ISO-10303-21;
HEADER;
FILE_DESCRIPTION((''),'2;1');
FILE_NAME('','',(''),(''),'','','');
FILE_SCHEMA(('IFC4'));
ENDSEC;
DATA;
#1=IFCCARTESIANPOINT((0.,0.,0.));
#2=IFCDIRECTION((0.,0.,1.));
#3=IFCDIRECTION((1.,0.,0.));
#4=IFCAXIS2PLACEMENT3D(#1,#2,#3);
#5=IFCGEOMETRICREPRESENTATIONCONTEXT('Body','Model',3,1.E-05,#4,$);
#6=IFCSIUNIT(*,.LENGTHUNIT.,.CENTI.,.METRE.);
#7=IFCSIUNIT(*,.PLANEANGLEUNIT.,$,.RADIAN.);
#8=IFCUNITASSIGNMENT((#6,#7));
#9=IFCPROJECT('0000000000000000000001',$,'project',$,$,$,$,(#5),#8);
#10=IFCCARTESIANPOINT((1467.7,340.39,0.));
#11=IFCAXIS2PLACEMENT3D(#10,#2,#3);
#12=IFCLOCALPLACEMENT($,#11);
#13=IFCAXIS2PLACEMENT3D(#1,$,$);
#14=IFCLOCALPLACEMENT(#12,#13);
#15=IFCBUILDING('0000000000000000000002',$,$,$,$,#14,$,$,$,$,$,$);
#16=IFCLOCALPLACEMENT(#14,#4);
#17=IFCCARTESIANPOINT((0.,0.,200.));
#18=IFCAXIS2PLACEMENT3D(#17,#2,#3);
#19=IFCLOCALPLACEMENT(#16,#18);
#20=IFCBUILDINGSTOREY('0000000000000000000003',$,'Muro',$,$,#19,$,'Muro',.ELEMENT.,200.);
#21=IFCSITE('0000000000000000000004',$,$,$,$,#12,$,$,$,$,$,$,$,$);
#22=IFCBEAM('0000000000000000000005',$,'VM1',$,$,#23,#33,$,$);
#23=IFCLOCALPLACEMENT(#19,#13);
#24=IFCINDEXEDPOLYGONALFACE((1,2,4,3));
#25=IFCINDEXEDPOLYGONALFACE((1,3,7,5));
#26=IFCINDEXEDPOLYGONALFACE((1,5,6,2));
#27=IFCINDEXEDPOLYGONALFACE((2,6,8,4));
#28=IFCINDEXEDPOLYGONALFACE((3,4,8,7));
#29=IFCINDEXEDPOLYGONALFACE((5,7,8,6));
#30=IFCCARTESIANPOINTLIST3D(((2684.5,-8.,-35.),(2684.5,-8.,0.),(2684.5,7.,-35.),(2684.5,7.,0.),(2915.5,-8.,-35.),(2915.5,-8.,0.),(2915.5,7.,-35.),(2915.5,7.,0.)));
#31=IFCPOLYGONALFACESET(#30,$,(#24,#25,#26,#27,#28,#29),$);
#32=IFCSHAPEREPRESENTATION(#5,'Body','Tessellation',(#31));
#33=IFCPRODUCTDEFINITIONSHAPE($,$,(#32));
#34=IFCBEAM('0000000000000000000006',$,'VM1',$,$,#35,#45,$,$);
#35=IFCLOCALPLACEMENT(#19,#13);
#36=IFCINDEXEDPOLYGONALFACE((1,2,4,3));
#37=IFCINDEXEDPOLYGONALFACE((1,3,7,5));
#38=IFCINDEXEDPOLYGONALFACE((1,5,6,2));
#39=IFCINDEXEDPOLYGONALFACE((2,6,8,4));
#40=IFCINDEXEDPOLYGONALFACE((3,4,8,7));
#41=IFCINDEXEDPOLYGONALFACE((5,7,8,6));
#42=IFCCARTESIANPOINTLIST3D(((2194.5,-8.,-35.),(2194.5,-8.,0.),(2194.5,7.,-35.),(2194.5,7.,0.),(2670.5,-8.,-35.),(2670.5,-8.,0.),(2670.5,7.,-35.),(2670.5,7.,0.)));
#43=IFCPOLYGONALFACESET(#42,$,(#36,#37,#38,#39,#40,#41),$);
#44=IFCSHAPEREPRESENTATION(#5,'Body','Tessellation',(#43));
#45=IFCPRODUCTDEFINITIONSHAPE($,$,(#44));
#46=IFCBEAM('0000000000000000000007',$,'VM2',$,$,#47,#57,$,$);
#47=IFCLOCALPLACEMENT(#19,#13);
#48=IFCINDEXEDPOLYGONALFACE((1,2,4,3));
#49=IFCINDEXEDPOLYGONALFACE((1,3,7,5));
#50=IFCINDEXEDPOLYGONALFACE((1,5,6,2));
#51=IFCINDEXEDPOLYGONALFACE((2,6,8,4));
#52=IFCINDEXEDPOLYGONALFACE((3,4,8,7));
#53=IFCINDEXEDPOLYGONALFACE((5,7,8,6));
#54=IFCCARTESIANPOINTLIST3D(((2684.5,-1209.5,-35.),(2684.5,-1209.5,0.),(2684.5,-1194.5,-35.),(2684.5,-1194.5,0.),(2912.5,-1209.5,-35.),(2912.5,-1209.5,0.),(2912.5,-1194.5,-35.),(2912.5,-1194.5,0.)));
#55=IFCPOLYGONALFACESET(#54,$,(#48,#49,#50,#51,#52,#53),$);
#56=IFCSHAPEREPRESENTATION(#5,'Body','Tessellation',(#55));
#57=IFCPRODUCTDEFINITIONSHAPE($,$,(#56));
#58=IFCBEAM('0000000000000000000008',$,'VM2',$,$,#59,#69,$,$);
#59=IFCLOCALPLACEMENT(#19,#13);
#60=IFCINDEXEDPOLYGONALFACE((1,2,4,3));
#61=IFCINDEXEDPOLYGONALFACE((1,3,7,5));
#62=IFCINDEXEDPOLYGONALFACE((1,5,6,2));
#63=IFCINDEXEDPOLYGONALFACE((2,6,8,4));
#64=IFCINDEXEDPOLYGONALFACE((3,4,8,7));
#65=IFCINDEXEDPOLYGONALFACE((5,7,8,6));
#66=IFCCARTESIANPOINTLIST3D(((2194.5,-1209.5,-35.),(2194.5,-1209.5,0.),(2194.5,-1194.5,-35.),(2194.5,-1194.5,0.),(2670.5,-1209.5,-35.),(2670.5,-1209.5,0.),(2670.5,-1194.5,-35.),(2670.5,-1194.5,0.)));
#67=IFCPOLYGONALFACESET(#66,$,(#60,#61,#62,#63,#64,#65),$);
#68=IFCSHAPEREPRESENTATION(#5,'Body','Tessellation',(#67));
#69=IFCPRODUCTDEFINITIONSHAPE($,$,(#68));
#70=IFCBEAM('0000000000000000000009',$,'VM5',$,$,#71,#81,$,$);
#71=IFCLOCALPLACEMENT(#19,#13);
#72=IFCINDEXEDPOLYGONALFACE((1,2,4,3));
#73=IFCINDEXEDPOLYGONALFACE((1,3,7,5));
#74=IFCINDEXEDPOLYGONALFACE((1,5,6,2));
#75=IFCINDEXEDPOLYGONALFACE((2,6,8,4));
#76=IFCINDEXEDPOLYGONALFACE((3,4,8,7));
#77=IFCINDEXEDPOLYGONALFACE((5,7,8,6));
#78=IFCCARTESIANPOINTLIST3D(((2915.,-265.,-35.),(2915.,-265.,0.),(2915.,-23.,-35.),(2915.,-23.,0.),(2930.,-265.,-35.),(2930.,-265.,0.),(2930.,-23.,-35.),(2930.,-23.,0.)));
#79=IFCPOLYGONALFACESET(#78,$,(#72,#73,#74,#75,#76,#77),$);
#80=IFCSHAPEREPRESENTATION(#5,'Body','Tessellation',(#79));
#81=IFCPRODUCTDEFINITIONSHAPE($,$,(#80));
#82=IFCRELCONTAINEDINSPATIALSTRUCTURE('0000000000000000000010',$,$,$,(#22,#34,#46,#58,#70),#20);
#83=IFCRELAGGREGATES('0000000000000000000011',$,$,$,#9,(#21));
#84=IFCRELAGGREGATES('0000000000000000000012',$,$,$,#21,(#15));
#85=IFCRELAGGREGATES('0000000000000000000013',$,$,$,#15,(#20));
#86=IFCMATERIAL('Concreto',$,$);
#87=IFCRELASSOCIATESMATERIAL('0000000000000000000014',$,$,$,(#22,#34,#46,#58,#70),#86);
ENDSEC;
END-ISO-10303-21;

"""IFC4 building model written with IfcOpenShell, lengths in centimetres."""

from ifc_helpers import new_model, si_unit, frame, origin, origin_with_axes, origin_2d_with_axis, place, context, project, spatial, rectangle, extrude, material, element, save


model = new_model("IFC4")

# Units and contexts
model_context = context("Model", 3, precision=1e-05, world=origin_with_axes(), identifier="Body")
ifc_project = project(units=[si_unit("LENGTHUNIT", "METRE", prefix="CENTI"), si_unit("PLANEANGLEUNIT", "RADIAN")], contexts=[model_context])

# Site, building, storey
site_placement = place(None, frame((1467.7, 340.39, 0.0), z_axis=(0.0, 0.0, 1.0), x_axis=(1.0, 0.0, 0.0)))
site = spatial("IfcSite", under=ifc_project, at=site_placement)
building_placement = place(site_placement, origin())
building = spatial("IfcBuilding", under=site, at=building_placement)
placement = place(building_placement, origin_with_axes())
storey_placement = place(placement, frame((0.0, 0.0, 200.0), z_axis=(0.0, 0.0, 1.0), x_axis=(1.0, 0.0, 0.0)))
storey = spatial("IfcBuildingStorey", under=building, at=storey_placement, Name="Muro", LongName="Muro", CompositionType="ELEMENT", Elevation=200.0)

# Shared definitions
ifc_material = material(Name="Concreto")

# Beams
beam_1_placement = place(storey_placement, frame((2800.0, -0.5, 0.0), z_axis=(0.0, 0.0, 1.0), x_axis=(1.0, 0.0, 0.0)))
element("IfcBeam", 1, at=beam_1_placement, inside=storey, material=ifc_material, Name="VM1", context=model_context, shape_type="SolidModel", body=[
    extrude(rectangle(XDim=15.0, YDim=35.0, at=origin_2d_with_axis()), frame((-115.5, 0.0, -17.5), z_axis=(1.0, 0.0, 0.0), x_axis=(0.0, 1.0, 0.0)), (0.0, 0.0, 1.0), 231.0),
])
beam_2_placement = place(storey_placement, frame((2432.5, -0.5, 0.0), z_axis=(0.0, 0.0, 1.0), x_axis=(1.0, 0.0, 0.0)))
element("IfcBeam", 2, at=beam_2_placement, inside=storey, material=ifc_material, Name="VM1", context=model_context, shape_type="SolidModel", body=[
    extrude(rectangle(XDim=15.0, YDim=35.0, at=origin_2d_with_axis()), frame((-238.0, 0.0, -17.5), z_axis=(1.0, 0.0, 0.0), x_axis=(0.0, 1.0, 0.0)), (0.0, 0.0, 1.0), 476.0),
])
beam_3_placement = place(storey_placement, frame((2798.5, -1202.0, 0.0), z_axis=(0.0, 0.0, 1.0), x_axis=(1.0, 0.0, 0.0)))
element("IfcBeam", 3, at=beam_3_placement, inside=storey, material=ifc_material, Name="VM2", context=model_context, shape_type="SolidModel", body=[
    extrude(rectangle(XDim=15.0, YDim=35.0, at=origin_2d_with_axis()), frame((-114.0, 0.0, -17.5), z_axis=(1.0, 0.0, 0.0), x_axis=(0.0, 1.0, 0.0)), (0.0, 0.0, 1.0), 228.0),
])
beam_4_placement = place(storey_placement, frame((2432.5, -1202.0, 0.0), z_axis=(0.0, 0.0, 1.0), x_axis=(1.0, 0.0, 0.0)))
element("IfcBeam", 4, at=beam_4_placement, inside=storey, material=ifc_material, Name="VM2", context=model_context, shape_type="SolidModel", body=[
    extrude(rectangle(XDim=15.0, YDim=35.0, at=origin_2d_with_axis()), frame((-238.0, 0.0, -17.5), z_axis=(1.0, 0.0, 0.0), x_axis=(0.0, 1.0, 0.0)), (0.0, 0.0, 1.0), 476.0),
])
beam_5_placement = place(storey_placement, frame((2922.5, -144.0, 0.0), z_axis=(0.0, 0.0, 1.0), x_axis=(1.0, 0.0, 0.0)))
element("IfcBeam", 5, at=beam_5_placement, inside=storey, material=ifc_material, Name="VM5", context=model_context, shape_type="SolidModel", body=[
    extrude(rectangle(XDim=15.0, YDim=35.0, at=origin_2d_with_axis()), frame((0.0, -121.0, -17.5), z_axis=(0.0, 1.0, 0.0), x_axis=(1.0, 0.0, 0.0)), (0.0, 0.0, 1.0), 242.0),
])

save(model, "model.ifc")
